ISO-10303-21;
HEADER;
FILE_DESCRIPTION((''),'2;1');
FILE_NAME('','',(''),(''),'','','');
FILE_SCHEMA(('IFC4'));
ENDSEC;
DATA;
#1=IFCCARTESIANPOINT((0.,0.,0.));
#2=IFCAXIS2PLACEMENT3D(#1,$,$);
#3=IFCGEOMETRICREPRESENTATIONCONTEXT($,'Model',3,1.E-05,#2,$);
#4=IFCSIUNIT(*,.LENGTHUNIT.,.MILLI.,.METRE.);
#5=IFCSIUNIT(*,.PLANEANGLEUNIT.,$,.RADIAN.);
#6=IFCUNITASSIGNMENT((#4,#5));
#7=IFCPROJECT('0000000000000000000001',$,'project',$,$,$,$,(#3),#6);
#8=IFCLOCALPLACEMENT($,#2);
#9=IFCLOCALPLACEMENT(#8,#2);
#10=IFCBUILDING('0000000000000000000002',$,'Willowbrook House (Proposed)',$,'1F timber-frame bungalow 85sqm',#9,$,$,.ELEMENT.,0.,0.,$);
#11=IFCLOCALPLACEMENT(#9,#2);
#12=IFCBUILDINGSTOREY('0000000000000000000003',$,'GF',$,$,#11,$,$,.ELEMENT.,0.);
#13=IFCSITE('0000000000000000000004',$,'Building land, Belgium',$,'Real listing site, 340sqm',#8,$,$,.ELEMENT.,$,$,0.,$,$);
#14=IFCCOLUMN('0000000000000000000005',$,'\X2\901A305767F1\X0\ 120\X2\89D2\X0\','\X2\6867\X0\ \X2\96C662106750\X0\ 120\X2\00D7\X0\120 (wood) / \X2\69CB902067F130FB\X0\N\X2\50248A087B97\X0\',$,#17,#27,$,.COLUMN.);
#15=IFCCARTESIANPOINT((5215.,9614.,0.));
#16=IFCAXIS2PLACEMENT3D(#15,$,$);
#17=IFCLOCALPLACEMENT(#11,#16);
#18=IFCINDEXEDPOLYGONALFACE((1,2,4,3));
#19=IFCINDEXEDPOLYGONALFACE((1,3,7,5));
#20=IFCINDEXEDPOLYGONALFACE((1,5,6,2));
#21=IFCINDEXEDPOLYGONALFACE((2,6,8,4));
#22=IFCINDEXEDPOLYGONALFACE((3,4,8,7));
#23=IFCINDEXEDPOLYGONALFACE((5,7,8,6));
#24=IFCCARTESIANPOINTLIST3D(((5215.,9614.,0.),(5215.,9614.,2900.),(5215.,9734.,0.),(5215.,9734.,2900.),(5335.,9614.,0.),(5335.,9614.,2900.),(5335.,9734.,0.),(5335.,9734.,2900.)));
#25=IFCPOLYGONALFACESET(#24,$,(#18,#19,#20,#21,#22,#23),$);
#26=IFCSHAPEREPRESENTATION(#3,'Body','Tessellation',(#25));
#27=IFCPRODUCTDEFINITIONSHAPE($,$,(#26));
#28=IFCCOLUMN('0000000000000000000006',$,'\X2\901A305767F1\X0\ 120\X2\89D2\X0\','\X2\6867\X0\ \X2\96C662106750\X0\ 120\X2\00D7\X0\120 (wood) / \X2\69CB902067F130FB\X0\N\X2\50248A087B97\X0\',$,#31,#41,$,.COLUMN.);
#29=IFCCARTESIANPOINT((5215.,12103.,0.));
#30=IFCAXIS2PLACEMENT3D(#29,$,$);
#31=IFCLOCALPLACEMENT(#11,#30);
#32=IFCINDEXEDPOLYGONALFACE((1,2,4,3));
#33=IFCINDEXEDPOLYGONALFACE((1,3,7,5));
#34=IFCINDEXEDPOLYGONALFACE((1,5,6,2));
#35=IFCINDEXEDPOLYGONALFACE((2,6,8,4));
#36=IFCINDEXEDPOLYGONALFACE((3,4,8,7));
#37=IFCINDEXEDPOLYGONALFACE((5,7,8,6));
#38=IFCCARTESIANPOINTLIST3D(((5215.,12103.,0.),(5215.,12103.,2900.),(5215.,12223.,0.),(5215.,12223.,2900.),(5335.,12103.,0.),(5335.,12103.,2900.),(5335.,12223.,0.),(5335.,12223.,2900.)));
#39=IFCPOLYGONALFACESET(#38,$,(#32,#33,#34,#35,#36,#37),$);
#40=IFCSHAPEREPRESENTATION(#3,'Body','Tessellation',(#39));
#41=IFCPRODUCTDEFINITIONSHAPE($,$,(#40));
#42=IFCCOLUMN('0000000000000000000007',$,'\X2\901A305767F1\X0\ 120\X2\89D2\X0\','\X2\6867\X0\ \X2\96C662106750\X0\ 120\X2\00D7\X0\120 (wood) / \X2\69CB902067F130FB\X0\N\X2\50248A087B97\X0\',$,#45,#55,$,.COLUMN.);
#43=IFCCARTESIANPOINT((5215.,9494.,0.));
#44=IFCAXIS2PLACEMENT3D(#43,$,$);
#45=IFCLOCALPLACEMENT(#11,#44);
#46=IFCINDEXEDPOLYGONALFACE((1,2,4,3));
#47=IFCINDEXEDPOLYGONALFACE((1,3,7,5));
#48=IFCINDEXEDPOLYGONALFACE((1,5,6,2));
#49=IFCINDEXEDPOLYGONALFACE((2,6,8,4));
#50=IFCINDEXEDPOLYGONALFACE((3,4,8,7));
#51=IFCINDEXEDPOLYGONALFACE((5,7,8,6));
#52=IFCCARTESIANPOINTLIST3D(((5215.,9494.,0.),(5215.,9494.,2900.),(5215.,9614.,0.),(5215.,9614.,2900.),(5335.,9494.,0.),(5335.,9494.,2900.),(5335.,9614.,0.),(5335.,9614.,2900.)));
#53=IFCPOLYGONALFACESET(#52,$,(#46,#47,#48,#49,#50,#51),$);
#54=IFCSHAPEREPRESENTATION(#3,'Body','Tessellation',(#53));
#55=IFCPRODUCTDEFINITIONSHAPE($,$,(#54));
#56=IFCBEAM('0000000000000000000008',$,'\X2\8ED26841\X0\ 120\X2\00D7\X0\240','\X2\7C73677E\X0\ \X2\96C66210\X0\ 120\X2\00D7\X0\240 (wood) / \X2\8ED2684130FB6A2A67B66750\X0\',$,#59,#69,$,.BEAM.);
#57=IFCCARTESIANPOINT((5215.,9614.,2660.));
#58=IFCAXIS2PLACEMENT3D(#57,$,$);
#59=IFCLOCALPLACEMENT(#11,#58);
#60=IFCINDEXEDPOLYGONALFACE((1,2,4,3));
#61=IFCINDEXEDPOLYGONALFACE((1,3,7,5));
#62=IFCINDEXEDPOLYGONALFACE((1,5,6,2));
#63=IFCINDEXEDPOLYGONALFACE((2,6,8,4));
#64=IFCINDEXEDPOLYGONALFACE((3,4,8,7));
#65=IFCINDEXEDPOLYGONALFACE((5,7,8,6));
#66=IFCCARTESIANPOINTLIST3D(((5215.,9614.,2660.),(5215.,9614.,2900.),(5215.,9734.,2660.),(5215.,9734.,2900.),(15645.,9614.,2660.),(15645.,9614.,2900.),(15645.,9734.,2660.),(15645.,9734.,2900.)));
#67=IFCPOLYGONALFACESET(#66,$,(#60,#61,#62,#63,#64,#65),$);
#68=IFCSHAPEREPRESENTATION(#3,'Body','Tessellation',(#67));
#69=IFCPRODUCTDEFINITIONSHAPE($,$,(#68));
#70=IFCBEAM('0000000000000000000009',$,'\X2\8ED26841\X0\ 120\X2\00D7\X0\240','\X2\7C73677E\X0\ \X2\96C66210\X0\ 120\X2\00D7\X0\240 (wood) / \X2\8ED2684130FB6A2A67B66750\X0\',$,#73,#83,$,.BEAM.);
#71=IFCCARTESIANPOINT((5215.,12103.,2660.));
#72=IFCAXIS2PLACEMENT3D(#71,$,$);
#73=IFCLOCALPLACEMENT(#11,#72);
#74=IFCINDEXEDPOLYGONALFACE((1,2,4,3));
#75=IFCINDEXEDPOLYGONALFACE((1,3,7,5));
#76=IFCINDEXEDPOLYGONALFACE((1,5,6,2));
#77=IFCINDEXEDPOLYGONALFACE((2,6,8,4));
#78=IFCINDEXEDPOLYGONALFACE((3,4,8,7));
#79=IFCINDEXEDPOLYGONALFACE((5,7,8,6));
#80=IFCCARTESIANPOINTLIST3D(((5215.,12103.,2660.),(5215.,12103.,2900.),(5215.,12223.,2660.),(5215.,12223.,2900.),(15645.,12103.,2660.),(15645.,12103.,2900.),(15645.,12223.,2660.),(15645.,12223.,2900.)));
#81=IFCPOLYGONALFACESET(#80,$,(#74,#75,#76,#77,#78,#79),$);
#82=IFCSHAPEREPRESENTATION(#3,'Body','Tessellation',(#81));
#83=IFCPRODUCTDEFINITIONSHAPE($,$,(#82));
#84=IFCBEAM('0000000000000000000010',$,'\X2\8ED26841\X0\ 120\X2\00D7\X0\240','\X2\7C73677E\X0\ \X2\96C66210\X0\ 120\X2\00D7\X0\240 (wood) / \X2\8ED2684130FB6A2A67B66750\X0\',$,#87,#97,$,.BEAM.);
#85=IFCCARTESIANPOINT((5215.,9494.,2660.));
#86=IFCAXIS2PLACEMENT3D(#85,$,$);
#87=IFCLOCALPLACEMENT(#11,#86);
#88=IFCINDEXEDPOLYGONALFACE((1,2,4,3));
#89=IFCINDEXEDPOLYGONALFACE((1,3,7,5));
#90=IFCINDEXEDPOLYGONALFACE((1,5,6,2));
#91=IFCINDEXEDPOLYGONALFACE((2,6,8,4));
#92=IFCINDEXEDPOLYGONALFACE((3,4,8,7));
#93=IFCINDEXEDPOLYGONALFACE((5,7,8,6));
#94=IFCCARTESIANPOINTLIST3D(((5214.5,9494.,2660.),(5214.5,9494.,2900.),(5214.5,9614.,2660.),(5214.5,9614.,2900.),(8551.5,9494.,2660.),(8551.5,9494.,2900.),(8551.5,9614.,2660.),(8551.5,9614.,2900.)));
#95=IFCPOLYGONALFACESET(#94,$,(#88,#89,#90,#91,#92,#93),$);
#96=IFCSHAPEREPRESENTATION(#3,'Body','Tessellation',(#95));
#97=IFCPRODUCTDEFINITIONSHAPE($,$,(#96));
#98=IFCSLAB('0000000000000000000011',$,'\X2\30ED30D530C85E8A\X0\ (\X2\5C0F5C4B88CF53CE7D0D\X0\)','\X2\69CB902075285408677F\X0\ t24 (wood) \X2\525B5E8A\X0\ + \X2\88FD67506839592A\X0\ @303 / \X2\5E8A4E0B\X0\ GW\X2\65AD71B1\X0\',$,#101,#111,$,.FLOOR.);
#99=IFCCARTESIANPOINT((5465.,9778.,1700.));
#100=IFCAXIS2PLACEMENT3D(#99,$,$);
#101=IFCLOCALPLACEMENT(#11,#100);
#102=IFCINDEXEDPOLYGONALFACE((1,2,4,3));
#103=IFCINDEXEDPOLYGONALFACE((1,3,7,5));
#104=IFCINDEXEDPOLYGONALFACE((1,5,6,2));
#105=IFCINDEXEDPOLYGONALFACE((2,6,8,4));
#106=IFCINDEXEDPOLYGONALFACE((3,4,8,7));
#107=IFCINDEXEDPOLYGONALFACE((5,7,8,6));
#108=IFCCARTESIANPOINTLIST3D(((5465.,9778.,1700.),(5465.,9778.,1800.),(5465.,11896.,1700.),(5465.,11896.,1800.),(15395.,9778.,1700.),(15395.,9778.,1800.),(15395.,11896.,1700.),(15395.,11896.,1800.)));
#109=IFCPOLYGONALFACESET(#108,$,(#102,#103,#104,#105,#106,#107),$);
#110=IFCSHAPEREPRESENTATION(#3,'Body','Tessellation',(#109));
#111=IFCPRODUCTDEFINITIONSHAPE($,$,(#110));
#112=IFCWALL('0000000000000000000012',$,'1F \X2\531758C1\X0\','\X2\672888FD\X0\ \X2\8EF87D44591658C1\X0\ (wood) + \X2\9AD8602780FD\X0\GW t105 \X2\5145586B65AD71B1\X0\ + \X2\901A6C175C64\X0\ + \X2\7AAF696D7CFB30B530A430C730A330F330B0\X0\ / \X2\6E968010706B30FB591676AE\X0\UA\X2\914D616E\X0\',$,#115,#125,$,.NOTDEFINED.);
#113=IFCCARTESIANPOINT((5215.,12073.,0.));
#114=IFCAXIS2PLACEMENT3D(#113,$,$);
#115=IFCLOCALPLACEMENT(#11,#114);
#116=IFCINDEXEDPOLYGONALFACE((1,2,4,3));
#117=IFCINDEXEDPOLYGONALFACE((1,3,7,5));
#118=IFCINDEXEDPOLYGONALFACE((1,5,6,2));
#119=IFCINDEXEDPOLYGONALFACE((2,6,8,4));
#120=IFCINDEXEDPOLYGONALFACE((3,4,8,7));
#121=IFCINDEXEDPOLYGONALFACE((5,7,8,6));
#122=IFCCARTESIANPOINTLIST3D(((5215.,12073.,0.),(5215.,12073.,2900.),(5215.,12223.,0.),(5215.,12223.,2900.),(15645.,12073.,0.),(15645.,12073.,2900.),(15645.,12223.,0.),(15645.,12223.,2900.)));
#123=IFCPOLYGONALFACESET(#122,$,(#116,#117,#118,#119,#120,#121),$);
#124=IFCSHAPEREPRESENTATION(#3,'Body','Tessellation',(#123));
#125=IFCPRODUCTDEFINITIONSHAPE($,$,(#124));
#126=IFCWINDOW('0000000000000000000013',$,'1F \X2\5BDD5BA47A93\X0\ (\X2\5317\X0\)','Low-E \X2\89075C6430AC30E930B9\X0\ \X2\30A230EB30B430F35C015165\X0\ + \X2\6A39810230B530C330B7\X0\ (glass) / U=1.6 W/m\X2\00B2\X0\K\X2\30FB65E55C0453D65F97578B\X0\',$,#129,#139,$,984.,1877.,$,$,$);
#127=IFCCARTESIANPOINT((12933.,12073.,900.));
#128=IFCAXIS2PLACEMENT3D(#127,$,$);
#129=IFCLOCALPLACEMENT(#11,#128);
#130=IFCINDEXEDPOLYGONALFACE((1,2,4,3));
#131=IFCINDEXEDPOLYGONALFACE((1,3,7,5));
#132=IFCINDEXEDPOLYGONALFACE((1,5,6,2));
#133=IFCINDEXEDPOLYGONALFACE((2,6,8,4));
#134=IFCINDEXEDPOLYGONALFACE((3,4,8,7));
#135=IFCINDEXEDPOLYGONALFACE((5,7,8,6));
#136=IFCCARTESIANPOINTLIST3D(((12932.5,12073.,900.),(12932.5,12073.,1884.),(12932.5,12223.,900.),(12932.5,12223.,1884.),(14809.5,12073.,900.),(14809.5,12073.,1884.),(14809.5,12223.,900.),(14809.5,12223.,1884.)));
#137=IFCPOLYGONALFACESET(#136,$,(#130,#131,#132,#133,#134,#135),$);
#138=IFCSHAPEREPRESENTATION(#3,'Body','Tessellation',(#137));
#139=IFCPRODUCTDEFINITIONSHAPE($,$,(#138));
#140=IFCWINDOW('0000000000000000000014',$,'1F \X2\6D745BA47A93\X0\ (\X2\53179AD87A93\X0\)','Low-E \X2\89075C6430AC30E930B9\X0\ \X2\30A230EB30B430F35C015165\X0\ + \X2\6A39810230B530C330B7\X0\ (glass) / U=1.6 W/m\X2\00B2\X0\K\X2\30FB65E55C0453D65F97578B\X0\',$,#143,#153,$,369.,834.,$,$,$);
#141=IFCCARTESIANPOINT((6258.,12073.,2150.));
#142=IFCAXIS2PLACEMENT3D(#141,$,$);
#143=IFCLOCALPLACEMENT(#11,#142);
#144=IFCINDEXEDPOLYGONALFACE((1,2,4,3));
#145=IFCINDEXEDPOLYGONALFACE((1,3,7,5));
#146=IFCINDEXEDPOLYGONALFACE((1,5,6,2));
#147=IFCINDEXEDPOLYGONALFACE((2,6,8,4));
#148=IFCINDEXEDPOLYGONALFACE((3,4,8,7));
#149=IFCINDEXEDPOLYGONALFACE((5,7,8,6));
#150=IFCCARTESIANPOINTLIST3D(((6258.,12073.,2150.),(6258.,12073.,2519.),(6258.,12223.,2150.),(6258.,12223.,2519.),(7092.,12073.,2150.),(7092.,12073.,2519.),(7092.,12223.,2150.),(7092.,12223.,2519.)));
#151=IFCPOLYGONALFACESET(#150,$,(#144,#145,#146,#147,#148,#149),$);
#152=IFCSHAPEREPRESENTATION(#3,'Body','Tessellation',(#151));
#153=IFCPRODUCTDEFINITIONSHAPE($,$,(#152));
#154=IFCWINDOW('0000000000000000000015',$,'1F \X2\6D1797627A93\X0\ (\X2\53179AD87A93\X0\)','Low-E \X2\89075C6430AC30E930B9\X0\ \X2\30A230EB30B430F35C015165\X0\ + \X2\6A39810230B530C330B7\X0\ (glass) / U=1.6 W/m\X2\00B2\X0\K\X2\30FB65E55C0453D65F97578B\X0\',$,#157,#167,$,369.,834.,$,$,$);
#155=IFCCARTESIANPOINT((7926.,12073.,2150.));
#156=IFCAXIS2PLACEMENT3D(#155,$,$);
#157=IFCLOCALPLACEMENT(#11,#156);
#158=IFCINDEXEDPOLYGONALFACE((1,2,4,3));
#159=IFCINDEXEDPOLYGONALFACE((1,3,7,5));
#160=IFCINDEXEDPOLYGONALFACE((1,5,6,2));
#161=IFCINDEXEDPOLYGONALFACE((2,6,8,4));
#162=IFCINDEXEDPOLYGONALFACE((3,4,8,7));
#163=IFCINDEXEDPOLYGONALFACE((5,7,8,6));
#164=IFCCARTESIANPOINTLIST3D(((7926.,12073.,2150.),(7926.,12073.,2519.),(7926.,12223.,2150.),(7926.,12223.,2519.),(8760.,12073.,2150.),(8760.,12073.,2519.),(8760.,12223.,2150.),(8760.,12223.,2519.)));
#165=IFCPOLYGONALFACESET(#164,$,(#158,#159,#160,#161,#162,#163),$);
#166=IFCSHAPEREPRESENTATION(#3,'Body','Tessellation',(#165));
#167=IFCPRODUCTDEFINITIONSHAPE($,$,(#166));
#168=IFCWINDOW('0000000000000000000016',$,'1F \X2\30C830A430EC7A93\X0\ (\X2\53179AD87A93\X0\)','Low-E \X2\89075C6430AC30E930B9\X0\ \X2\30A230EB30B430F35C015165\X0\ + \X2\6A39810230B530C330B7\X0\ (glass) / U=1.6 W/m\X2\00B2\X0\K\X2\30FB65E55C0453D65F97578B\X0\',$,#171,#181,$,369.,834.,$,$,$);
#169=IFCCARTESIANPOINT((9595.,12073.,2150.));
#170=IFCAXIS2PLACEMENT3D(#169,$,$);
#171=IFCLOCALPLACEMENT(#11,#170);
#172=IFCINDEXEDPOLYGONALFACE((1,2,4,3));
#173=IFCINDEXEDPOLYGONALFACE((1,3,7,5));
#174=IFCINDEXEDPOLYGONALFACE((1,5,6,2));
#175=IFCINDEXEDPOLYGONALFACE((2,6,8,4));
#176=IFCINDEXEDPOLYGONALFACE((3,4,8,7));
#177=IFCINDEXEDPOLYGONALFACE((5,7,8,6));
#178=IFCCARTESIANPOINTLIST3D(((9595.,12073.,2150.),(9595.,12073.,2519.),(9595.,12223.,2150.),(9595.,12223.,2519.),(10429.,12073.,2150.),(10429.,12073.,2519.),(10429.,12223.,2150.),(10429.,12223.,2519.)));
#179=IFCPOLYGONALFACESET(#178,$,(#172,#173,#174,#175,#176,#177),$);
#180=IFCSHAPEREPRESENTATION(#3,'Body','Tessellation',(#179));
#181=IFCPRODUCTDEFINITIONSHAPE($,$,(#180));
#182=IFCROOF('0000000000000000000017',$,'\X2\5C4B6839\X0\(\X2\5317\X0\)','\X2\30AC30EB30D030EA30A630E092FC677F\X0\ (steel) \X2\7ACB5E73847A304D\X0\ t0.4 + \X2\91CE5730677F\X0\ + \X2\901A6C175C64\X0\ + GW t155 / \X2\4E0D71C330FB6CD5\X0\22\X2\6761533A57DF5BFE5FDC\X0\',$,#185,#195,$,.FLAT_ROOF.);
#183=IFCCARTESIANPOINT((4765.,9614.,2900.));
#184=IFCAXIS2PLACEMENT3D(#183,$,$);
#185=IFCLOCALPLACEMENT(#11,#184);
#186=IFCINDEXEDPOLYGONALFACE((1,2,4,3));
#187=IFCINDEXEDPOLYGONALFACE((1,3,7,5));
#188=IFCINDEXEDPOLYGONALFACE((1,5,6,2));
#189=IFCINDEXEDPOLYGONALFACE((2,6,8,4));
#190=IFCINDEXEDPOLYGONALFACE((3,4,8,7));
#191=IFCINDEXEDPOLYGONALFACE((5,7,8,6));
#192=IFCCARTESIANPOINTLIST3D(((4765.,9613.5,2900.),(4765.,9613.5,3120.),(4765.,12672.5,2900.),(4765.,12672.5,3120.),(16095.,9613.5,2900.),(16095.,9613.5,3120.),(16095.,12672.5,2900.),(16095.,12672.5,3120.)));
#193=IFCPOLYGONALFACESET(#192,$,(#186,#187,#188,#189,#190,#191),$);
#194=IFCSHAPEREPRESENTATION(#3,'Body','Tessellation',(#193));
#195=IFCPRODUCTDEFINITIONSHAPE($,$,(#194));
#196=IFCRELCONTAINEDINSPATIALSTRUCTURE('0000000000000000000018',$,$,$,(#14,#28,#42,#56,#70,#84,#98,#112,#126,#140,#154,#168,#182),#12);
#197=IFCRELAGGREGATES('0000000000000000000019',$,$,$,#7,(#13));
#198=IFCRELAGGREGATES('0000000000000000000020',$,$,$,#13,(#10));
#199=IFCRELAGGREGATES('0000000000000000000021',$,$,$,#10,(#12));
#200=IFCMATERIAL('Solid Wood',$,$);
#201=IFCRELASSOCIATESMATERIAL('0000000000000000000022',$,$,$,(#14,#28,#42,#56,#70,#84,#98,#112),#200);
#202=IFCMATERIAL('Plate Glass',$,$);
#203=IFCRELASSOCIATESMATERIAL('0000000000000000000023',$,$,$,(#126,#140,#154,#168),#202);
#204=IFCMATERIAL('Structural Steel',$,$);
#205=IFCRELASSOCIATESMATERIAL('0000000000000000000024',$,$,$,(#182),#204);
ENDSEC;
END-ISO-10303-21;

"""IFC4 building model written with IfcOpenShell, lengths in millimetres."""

from ifc_helpers import new_model, si_unit, frame, frame_2d, origin, place, context, project, spatial, rectangle, extrude, material, element, fill, save


model = new_model("IFC4")

# Units and contexts
model_context = context("Model", 3, precision=1e-05, world=origin())
ifc_project = project(units=[si_unit("LENGTHUNIT", "METRE", prefix="MILLI"), si_unit("PLANEANGLEUNIT", "RADIAN")], contexts=[model_context])

# Site, building, storey
site_placement = place(None, origin())
site = spatial("IfcSite", under=ifc_project, at=site_placement, Name="Building land, Belgium", ObjectType="Real listing site, 340sqm", CompositionType="ELEMENT", RefElevation=0.0)
building_placement = place(site_placement, origin())
building = spatial("IfcBuilding", under=site, at=building_placement, Name="Willowbrook House (Proposed)", ObjectType="1F timber-frame bungalow 85sqm", CompositionType="ELEMENT", ElevationOfRefHeight=0.0, ElevationOfTerrain=0.0)
storey_placement = place(building_placement, origin())
storey = spatial("IfcBuildingStorey", under=building, at=storey_placement, Name="GF", CompositionType="ELEMENT", Elevation=0.0)

# Columns
ifc_material_1 = material(Name="Solid Wood")
column_1_placement = place(storey_placement, frame((5215.0, 9614.0, 0.0)))
element("IfcColumn", 1, at=column_1_placement, inside=storey, material=ifc_material_1, Name="通し柱 120角", Description="桧 集成材 120×120 (wood) / 構造柱・N値計算", PredefinedType="COLUMN", context=model_context, shape_type="SweptSolid", body=[
    extrude(rectangle(XDim=120.0, YDim=120.0, at=frame_2d((60.0, 60.0))), frame((5215.0, 9614.0, 0.0)), (0.0, 0.0, 1.0), 2900.0),
])
column_2_placement = place(storey_placement, frame((5215.0, 12103.0, 0.0)))
element("IfcColumn", 2, at=column_2_placement, inside=storey, material=ifc_material_1, Name="通し柱 120角", Description="桧 集成材 120×120 (wood) / 構造柱・N値計算", PredefinedType="COLUMN", context=model_context, shape_type="SweptSolid", body=[
    extrude(rectangle(XDim=120.0, YDim=120.0, at=frame_2d((60.0, 60.0))), frame((5215.0, 12103.0, 0.0)), (0.0, 0.0, 1.0), 2900.0),
])
column_3_placement = place(storey_placement, frame((5215.0, 9494.0, 0.0)))
element("IfcColumn", 3, at=column_3_placement, inside=storey, material=ifc_material_1, Name="通し柱 120角", Description="桧 集成材 120×120 (wood) / 構造柱・N値計算", PredefinedType="COLUMN", context=model_context, shape_type="SweptSolid", body=[
    extrude(rectangle(XDim=120.0, YDim=120.0, at=frame_2d((60.0, 60.0))), frame((5215.0, 9494.0, 0.0)), (0.0, 0.0, 1.0), 2900.0),
])

# Beams
beam_1_placement = place(storey_placement, frame((5215.0, 9614.0, 2660.0)))
element("IfcBeam", 4, at=beam_1_placement, inside=storey, material=ifc_material_1, Name="軒桁 120×240", Description="米松 集成 120×240 (wood) / 軒桁・横架材", PredefinedType="BEAM", context=model_context, shape_type="SweptSolid", body=[
    extrude(rectangle(XDim=10430.0, YDim=120.0, at=frame_2d((5215.0, 60.0))), frame((5215.0, 9614.0, 2660.0)), (0.0, 0.0, 1.0), 240.0),
])
beam_2_placement = place(storey_placement, frame((5215.0, 12103.0, 2660.0)))
element("IfcBeam", 5, at=beam_2_placement, inside=storey, material=ifc_material_1, Name="軒桁 120×240", Description="米松 集成 120×240 (wood) / 軒桁・横架材", PredefinedType="BEAM", context=model_context, shape_type="SweptSolid", body=[
    extrude(rectangle(XDim=10430.0, YDim=120.0, at=frame_2d((5215.0, 60.0))), frame((5215.0, 12103.0, 2660.0)), (0.0, 0.0, 1.0), 240.0),
])
beam_3_placement = place(storey_placement, frame((5215.0, 9494.0, 2660.0)))
element("IfcBeam", 6, at=beam_3_placement, inside=storey, material=ifc_material_1, Name="軒桁 120×240", Description="米松 集成 120×240 (wood) / 軒桁・横架材", PredefinedType="BEAM", context=model_context, shape_type="SweptSolid", body=[
    extrude(rectangle(XDim=3337.0, YDim=120.0, at=frame_2d((1668.0, 60.0))), frame((5215.0, 9494.0, 2660.0)), (0.0, 0.0, 1.0), 240.0),
])

# Slab
slab_1_placement = place(storey_placement, frame((5465.0, 9778.0, 1700.0)))
element("IfcSlab", 7, at=slab_1_placement, inside=storey, material=ifc_material_1, Name="ロフト床 (小屋裏収納)", Description="構造用合板 t24 (wood) 剛床 + 製材根太 @303 / 床下 GW断熱", PredefinedType="FLOOR", context=model_context, shape_type="SweptSolid", body=[
    extrude(rectangle(XDim=9930.0, YDim=2118.0, at=frame_2d((4965.0, 1059.0))), frame((5465.0, 9778.0, 1700.0)), (0.0, 0.0, 1.0), 100.0),
])

# Wall, openings, windows
wall_1_placement = place(storey_placement, frame((5215.0, 12073.0, 0.0)))
wall_1 = element("IfcWall", 8, at=wall_1_placement, inside=storey, material=ifc_material_1, Name="1F 北壁", Description="木製 軸組外壁 (wood) + 高性能GW t105 充填断熱 + 通気層 + 窯業系サイディング / 準耐火・外皮UA配慮", PredefinedType="NOTDEFINED", context=model_context, shape_type="SweptSolid", body=[
    extrude(rectangle(XDim=10430.0, YDim=150.0, at=frame_2d((5215.0, 75.0))), frame((5215.0, 12073.0, 0.0)), (0.0, 0.0, 1.0), 2900.0),
])
opening_1_placement = place(storey_placement, frame((12933.0, 12073.0, 900.0)))
opening_1 = element("IfcOpeningElement", 9, at=opening_1_placement, cuts=wall_1, PredefinedType="NOTDEFINED", context=model_context, shape_type="SweptSolid", body=[
    extrude(rectangle(XDim=1877.0, YDim=150.0, at=frame_2d((938.0, 75.0))), frame((12933.0, 12073.0, 900.0)), (0.0, 0.0, 1.0), 984.0),
])
opening_2_placement = place(storey_placement, frame((6258.0, 12073.0, 2150.0)))
opening_2 = element("IfcOpeningElement", 10, at=opening_2_placement, cuts=wall_1, PredefinedType="NOTDEFINED", context=model_context, shape_type="SweptSolid", body=[
    extrude(rectangle(XDim=834.0, YDim=150.0, at=frame_2d((417.0, 75.0))), frame((6258.0, 12073.0, 2150.0)), (0.0, 0.0, 1.0), 369.0),
])
opening_3_placement = place(storey_placement, frame((7926.0, 12073.0, 2150.0)))
opening_3 = element("IfcOpeningElement", 11, at=opening_3_placement, cuts=wall_1, PredefinedType="NOTDEFINED", context=model_context, shape_type="SweptSolid", body=[
    extrude(rectangle(XDim=834.0, YDim=150.0, at=frame_2d((417.0, 75.0))), frame((7926.0, 12073.0, 2150.0)), (0.0, 0.0, 1.0), 369.0),
])
opening_4_placement = place(storey_placement, frame((9595.0, 12073.0, 2150.0)))
opening_4 = element("IfcOpeningElement", 12, at=opening_4_placement, cuts=wall_1, PredefinedType="NOTDEFINED", context=model_context, shape_type="SweptSolid", body=[
    extrude(rectangle(XDim=834.0, YDim=150.0, at=frame_2d((417.0, 75.0))), frame((9595.0, 12073.0, 2150.0)), (0.0, 0.0, 1.0), 369.0),
])
ifc_material_2 = material(Name="Plate Glass")
window_1_placement = place(storey_placement, frame((12933.0, 12073.0, 900.0)))
window_1 = element("IfcWindow", 13, at=window_1_placement, inside=storey, material=ifc_material_2, Name="1F 寝室窓 (北)", Description="Low-E 複層ガラス アルゴン封入 + 樹脂サッシ (glass) / U=1.6 W/m²K・日射取得型", OverallHeight=984.0, OverallWidth=1877.0, context=model_context, shape_type="SweptSolid", body=[
    extrude(rectangle(XDim=1877.0, YDim=150.0, at=frame_2d((938.0, 75.0))), frame((12933.0, 12073.0, 900.0)), (0.0, 0.0, 1.0), 984.0),
])
fill(opening_1, window_1)
window_2_placement = place(storey_placement, frame((6258.0, 12073.0, 2150.0)))
window_2 = element("IfcWindow", 14, at=window_2_placement, inside=storey, material=ifc_material_2, Name="1F 浴室窓 (北高窓)", Description="Low-E 複層ガラス アルゴン封入 + 樹脂サッシ (glass) / U=1.6 W/m²K・日射取得型", OverallHeight=369.0, OverallWidth=834.0, context=model_context, shape_type="SweptSolid", body=[
    extrude(rectangle(XDim=834.0, YDim=150.0, at=frame_2d((417.0, 75.0))), frame((6258.0, 12073.0, 2150.0)), (0.0, 0.0, 1.0), 369.0),
])
fill(opening_2, window_2)
window_3_placement = place(storey_placement, frame((7926.0, 12073.0, 2150.0)))
window_3 = element("IfcWindow", 15, at=window_3_placement, inside=storey, material=ifc_material_2, Name="1F 洗面窓 (北高窓)", Description="Low-E 複層ガラス アルゴン封入 + 樹脂サッシ (glass) / U=1.6 W/m²K・日射取得型", OverallHeight=369.0, OverallWidth=834.0, context=model_context, shape_type="SweptSolid", body=[
    extrude(rectangle(XDim=834.0, YDim=150.0, at=frame_2d((417.0, 75.0))), frame((7926.0, 12073.0, 2150.0)), (0.0, 0.0, 1.0), 369.0),
])
fill(opening_3, window_3)
window_4_placement = place(storey_placement, frame((9595.0, 12073.0, 2150.0)))
window_4 = element("IfcWindow", 16, at=window_4_placement, inside=storey, material=ifc_material_2, Name="1F トイレ窓 (北高窓)", Description="Low-E 複層ガラス アルゴン封入 + 樹脂サッシ (glass) / U=1.6 W/m²K・日射取得型", OverallHeight=369.0, OverallWidth=834.0, context=model_context, shape_type="SweptSolid", body=[
    extrude(rectangle(XDim=834.0, YDim=150.0, at=frame_2d((417.0, 75.0))), frame((9595.0, 12073.0, 2150.0)), (0.0, 0.0, 1.0), 369.0),
])
fill(opening_4, window_4)

# Roof
ifc_material_3 = material(Name="Structural Steel")
roof_placement = place(storey_placement, frame((4765.0, 9614.0, 2900.0)))
element("IfcRoof", 17, at=roof_placement, inside=storey, material=ifc_material_3, Name="屋根(北)", Description="ガルバリウム鋼板 (steel) 立平葺き t0.4 + 野地板 + 通気層 + GW t155 / 不燃・法22条区域対応", PredefinedType="FLAT_ROOF", context=model_context, shape_type="SweptSolid", body=[
    extrude(rectangle(XDim=11330.0, YDim=3059.0, at=frame_2d((5665.0, 1529.0))), frame((4765.0, 9614.0, 2900.0)), (0.0, 0.0, 1.0), 220.0),
])

save(model, "model.ifc")
